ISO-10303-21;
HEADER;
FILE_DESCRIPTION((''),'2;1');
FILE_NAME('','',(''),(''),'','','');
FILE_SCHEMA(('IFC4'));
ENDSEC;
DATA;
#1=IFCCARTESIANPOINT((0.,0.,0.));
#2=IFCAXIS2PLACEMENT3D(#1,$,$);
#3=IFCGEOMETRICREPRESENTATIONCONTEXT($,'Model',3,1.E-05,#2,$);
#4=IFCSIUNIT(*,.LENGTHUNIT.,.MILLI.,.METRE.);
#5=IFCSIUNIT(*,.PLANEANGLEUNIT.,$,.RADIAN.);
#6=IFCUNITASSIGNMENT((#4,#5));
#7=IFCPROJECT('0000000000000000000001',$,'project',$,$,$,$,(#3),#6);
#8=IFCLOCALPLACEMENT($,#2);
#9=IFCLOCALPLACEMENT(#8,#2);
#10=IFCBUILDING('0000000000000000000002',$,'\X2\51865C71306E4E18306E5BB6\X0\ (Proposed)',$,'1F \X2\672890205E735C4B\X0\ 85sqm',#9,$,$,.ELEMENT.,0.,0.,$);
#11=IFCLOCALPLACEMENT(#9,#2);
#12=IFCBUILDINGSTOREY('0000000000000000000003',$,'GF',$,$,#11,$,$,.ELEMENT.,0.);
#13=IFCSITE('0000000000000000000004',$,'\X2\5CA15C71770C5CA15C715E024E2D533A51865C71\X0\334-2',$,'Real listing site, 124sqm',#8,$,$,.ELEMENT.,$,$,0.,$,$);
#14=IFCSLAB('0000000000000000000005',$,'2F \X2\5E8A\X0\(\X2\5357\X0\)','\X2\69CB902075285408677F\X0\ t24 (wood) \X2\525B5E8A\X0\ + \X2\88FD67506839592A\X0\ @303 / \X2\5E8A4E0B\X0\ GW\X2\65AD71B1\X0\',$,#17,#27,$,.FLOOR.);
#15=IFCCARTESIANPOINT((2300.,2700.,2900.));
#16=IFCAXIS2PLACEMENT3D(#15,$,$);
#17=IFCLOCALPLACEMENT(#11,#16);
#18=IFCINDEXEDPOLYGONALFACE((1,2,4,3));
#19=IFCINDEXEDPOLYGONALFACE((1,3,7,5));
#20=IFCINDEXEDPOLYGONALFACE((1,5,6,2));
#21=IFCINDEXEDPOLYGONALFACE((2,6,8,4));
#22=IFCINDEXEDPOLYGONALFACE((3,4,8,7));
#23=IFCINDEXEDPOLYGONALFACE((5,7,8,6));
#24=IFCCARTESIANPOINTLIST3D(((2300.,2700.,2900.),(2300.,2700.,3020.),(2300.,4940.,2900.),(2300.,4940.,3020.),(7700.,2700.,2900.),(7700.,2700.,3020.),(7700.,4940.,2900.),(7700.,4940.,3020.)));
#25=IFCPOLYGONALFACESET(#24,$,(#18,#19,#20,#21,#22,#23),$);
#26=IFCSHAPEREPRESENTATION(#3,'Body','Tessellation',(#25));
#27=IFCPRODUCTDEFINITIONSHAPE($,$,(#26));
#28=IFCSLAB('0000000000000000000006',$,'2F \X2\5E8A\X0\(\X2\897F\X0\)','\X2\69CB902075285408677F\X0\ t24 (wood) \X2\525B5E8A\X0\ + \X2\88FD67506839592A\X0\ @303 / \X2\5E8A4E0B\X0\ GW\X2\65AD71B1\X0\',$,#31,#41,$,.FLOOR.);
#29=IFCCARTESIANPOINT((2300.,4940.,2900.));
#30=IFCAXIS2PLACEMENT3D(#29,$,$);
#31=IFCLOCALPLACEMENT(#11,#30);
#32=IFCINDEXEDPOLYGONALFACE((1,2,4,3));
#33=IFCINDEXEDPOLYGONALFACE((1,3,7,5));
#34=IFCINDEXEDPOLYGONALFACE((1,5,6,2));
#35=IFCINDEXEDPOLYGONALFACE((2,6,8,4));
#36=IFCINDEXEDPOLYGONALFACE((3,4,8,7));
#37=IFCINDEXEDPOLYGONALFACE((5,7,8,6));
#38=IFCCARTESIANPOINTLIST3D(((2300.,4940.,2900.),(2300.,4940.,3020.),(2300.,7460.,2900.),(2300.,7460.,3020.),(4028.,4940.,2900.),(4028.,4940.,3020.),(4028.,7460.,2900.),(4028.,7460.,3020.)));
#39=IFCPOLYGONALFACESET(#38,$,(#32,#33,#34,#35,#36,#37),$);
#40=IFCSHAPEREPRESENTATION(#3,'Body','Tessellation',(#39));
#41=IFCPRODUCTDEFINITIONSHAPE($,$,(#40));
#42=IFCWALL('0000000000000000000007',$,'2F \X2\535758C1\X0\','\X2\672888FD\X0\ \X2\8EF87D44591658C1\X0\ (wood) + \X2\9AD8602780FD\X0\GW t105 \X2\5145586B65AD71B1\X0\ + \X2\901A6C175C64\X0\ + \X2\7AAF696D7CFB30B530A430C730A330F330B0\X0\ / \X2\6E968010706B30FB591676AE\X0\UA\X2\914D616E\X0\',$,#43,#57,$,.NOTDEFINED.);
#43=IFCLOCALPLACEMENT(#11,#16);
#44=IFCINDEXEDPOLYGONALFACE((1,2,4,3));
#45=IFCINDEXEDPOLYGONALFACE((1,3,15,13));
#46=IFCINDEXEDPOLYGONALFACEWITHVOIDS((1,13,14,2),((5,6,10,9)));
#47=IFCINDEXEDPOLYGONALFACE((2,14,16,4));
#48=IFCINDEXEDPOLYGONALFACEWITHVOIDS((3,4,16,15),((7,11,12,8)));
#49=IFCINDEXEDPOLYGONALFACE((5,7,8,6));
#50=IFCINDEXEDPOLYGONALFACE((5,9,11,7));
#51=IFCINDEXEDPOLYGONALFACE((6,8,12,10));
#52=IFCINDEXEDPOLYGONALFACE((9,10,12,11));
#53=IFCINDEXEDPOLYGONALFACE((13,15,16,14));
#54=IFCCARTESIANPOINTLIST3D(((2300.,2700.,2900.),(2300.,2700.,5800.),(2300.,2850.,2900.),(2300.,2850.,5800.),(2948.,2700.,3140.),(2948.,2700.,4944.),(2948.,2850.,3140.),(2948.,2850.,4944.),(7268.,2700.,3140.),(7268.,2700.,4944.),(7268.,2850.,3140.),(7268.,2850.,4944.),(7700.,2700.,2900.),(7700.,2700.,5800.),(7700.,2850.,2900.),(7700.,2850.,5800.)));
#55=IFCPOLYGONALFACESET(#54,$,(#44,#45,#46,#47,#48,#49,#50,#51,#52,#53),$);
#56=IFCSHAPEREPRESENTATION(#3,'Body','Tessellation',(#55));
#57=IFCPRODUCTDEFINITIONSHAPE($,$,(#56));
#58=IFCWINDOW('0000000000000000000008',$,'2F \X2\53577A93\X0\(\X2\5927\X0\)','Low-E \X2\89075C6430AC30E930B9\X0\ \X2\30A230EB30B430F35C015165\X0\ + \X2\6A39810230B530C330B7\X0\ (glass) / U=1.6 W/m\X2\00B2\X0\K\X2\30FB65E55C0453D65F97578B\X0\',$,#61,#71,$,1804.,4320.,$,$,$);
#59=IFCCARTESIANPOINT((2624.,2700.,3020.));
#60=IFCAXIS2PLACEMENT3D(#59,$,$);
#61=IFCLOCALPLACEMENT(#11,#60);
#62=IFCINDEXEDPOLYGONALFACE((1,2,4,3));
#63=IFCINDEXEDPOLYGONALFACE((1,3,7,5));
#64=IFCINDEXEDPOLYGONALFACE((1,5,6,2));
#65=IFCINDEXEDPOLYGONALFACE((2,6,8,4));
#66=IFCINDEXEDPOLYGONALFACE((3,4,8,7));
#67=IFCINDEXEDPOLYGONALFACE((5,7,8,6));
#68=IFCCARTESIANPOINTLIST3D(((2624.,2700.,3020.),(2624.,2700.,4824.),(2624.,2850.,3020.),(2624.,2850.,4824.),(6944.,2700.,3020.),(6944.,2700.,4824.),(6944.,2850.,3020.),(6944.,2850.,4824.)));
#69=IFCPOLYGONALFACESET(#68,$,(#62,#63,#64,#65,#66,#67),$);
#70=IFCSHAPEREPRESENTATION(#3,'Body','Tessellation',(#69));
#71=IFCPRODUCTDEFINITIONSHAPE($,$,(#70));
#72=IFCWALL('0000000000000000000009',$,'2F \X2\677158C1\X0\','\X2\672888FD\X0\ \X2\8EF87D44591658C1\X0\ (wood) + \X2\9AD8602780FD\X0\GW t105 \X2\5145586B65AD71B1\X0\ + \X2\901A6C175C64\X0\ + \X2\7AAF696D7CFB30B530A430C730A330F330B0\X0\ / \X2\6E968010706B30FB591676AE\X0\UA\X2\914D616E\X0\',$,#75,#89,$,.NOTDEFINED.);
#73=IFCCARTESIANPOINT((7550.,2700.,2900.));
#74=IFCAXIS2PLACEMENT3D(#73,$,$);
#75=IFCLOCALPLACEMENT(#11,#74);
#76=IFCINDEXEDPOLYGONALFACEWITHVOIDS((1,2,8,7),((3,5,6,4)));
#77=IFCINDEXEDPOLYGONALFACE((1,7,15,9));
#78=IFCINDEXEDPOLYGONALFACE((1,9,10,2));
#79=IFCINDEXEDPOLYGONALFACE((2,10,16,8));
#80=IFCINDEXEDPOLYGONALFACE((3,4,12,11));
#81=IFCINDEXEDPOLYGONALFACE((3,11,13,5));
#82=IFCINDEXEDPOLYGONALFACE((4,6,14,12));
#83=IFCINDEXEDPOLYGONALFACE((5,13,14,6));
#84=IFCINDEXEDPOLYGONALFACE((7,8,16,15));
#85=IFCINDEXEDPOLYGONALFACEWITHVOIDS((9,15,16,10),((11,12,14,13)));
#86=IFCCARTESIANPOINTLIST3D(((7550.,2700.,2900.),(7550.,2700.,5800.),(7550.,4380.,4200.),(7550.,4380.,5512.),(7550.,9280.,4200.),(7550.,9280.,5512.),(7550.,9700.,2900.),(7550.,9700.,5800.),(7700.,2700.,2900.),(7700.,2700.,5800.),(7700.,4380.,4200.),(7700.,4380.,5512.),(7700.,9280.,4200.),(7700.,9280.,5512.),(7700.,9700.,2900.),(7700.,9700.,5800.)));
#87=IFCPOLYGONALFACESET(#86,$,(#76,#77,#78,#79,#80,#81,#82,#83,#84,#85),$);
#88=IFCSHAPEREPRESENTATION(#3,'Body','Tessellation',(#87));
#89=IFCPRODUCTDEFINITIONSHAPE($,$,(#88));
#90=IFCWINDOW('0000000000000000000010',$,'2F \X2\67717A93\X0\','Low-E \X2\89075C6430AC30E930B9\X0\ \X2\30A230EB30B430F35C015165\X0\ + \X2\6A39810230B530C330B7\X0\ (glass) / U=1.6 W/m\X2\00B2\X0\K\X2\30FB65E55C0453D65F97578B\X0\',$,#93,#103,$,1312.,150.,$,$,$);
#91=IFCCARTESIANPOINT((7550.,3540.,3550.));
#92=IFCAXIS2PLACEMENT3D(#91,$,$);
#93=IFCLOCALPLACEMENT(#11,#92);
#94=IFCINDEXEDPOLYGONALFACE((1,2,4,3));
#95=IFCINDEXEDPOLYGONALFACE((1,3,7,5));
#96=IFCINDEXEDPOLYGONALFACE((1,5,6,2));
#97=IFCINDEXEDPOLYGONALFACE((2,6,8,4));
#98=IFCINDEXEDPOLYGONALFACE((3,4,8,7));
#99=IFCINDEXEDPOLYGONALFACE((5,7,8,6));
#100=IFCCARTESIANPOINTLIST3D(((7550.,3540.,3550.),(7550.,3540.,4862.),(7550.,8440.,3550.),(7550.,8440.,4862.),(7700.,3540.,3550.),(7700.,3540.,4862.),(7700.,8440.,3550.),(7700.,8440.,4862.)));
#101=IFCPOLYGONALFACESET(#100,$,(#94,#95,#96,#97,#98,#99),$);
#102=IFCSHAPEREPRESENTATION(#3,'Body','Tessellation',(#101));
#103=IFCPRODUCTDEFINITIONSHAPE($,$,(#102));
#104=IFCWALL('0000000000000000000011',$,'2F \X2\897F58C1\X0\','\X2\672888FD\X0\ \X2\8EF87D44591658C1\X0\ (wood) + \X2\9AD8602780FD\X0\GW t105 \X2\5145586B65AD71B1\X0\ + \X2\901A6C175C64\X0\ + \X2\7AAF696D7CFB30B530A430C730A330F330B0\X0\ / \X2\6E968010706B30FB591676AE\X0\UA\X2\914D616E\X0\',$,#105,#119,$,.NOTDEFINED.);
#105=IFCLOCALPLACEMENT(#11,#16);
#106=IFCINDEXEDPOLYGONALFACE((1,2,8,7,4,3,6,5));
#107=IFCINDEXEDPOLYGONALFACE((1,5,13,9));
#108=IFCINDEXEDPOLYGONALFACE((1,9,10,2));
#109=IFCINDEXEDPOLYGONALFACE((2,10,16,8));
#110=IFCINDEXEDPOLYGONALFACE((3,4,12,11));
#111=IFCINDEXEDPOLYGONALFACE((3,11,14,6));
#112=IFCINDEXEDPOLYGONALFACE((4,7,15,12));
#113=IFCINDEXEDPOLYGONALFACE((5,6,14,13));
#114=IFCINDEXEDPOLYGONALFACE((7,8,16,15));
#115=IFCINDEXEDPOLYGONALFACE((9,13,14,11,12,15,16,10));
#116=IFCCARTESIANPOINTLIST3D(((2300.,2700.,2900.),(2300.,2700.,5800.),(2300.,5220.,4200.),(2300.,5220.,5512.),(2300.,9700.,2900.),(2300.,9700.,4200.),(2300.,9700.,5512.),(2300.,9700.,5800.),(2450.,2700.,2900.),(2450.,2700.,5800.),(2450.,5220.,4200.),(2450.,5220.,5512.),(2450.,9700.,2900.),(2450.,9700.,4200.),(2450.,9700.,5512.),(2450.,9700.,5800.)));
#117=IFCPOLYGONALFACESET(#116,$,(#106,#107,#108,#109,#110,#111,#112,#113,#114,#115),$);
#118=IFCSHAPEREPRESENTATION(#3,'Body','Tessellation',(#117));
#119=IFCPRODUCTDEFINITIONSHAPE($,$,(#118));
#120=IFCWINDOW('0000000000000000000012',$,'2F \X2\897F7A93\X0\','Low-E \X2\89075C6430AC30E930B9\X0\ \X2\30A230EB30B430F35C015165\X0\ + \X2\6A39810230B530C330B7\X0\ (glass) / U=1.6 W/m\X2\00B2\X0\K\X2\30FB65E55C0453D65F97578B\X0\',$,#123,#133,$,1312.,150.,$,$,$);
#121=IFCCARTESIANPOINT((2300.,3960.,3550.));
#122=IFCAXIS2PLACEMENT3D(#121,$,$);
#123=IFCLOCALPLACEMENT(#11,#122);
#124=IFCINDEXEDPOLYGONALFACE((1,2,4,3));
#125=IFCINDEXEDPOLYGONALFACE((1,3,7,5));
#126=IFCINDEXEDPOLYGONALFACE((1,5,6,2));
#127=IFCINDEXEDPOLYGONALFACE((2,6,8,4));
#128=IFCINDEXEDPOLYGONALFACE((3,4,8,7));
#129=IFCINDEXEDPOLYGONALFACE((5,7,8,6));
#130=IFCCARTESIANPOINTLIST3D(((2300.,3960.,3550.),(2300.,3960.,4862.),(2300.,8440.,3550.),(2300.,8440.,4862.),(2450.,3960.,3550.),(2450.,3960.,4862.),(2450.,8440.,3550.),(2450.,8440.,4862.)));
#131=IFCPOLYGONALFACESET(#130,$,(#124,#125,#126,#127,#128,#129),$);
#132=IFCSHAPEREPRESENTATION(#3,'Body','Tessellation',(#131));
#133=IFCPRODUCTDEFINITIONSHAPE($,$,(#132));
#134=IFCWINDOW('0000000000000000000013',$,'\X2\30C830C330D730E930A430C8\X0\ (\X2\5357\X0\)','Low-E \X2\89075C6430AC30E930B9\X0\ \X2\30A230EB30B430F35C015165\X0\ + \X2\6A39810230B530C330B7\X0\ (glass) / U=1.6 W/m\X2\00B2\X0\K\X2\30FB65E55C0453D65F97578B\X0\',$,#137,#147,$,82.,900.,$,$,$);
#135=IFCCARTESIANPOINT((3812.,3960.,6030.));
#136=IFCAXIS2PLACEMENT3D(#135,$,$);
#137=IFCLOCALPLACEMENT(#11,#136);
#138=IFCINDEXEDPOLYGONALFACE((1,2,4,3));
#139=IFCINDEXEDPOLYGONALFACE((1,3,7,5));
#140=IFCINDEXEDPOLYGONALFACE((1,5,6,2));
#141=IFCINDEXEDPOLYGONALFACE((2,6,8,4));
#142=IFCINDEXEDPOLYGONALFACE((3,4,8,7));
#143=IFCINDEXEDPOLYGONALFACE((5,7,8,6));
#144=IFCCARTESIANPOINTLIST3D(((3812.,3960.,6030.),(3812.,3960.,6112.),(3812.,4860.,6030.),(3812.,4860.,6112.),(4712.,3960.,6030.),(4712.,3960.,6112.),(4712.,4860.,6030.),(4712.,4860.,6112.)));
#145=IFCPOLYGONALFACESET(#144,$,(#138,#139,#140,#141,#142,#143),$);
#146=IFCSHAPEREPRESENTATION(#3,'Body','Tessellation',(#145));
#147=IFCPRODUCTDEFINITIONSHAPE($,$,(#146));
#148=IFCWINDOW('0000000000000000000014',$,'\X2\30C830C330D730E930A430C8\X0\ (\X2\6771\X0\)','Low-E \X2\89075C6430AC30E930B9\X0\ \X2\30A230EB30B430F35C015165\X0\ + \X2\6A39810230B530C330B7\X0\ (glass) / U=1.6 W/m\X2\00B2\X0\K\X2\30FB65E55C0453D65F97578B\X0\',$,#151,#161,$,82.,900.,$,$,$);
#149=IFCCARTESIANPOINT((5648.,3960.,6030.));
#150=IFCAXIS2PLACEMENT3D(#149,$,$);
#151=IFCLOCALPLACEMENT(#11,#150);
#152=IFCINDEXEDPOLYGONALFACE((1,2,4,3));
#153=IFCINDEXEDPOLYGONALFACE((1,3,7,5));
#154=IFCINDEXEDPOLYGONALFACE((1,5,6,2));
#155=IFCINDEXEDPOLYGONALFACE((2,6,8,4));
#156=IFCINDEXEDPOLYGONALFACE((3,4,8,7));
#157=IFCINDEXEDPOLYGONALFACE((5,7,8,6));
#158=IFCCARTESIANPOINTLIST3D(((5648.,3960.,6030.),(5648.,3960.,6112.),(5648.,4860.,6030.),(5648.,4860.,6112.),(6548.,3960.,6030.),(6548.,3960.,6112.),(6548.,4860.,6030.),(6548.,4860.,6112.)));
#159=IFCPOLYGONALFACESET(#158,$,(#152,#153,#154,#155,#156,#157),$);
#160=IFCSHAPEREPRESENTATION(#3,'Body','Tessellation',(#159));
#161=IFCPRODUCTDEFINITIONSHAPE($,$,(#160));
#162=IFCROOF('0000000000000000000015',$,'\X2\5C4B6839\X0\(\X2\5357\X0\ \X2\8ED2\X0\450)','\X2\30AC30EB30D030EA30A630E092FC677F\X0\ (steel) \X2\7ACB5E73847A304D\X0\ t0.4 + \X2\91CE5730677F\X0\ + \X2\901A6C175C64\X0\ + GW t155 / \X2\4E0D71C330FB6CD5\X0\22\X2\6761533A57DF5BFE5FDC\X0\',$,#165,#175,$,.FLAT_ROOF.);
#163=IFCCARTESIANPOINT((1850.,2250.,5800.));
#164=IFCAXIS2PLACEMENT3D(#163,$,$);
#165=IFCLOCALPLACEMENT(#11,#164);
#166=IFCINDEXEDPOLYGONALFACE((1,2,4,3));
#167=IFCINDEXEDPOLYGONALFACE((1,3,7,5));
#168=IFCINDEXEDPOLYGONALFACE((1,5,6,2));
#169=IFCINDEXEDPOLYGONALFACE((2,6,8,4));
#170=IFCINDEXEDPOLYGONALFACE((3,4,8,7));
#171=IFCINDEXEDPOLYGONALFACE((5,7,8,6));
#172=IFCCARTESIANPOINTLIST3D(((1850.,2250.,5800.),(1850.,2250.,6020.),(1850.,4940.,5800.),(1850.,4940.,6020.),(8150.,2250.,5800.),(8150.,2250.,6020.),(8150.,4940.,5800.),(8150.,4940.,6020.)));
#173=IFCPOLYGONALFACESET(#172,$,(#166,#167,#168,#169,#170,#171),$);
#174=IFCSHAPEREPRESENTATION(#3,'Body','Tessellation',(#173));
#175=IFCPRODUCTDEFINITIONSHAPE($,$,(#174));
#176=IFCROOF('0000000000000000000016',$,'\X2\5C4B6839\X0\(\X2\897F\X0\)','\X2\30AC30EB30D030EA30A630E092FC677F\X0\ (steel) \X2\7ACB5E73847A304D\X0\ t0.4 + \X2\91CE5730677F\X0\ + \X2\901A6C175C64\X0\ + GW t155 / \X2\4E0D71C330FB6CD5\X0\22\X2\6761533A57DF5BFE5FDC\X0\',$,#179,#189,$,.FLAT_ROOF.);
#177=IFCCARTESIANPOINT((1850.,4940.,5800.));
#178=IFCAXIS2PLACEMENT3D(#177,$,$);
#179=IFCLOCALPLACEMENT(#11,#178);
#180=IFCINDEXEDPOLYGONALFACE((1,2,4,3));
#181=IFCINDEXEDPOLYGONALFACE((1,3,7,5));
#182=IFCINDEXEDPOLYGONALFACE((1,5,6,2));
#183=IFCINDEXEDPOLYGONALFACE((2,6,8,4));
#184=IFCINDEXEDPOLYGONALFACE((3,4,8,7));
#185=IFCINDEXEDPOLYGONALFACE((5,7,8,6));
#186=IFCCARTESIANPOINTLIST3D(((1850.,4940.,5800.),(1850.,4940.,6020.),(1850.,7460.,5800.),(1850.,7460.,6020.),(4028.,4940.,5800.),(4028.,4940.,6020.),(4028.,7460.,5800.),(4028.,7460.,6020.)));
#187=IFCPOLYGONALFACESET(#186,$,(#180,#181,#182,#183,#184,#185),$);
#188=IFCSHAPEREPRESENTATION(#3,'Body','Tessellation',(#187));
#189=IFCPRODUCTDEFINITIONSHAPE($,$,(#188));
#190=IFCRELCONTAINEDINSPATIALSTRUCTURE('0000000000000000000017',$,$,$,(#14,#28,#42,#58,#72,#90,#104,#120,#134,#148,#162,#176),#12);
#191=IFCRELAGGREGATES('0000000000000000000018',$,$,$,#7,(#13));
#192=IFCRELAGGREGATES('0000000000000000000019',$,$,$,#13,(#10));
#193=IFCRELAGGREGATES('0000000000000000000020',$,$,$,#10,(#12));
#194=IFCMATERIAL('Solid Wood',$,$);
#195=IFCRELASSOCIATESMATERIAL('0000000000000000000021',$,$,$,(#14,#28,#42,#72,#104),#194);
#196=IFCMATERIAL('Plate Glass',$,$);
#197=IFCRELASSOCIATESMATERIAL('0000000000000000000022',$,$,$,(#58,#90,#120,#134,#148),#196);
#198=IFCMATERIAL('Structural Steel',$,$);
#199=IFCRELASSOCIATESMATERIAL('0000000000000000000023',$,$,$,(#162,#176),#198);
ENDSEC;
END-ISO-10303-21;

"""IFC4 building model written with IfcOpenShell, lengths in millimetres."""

from ifc_helpers import new_model, si_unit, frame, frame_2d, origin, place, context, project, spatial, rectangle, extrude, material, element, fill, save


model = new_model("IFC4")

# Units and contexts
model_context = context("Model", 3, precision=1e-05, world=origin())
ifc_project = project(units=[si_unit("LENGTHUNIT", "METRE", prefix="MILLI"), si_unit("PLANEANGLEUNIT", "RADIAN")], contexts=[model_context])

# Site, building, storey
site_placement = place(None, origin())
site = spatial("IfcSite", under=ifc_project, at=site_placement, Name="岡山県岡山市中区円山334-2", ObjectType="Real listing site, 124sqm", CompositionType="ELEMENT", RefElevation=0.0)
building_placement = place(site_placement, origin())
building = spatial("IfcBuilding", under=site, at=building_placement, Name="円山の丘の家 (Proposed)", ObjectType="1F 木造平屋 85sqm", CompositionType="ELEMENT", ElevationOfRefHeight=0.0, ElevationOfTerrain=0.0)
storey_placement = place(building_placement, origin())
storey = spatial("IfcBuildingStorey", under=building, at=storey_placement, Name="GF", CompositionType="ELEMENT", Elevation=0.0)

# Slabs
ifc_material_1 = material(Name="Solid Wood")
slab_1_placement = place(storey_placement, frame((2300.0, 2700.0, 2900.0)))
element("IfcSlab", 1, at=slab_1_placement, inside=storey, material=ifc_material_1, Name="2F 床(南)", Description="構造用合板 t24 (wood) 剛床 + 製材根太 @303 / 床下 GW断熱", PredefinedType="FLOOR", context=model_context, shape_type="SweptSolid", body=[
    extrude(rectangle(XDim=5400.0, YDim=2240.0, at=frame_2d((2700.0, 1120.0))), frame((2300.0, 2700.0, 2900.0)), (0.0, 0.0, 1.0), 120.0),
])
slab_2_placement = place(storey_placement, frame((2300.0, 4940.0, 2900.0)))
element("IfcSlab", 2, at=slab_2_placement, inside=storey, material=ifc_material_1, Name="2F 床(西)", Description="構造用合板 t24 (wood) 剛床 + 製材根太 @303 / 床下 GW断熱", PredefinedType="FLOOR", context=model_context, shape_type="SweptSolid", body=[
    extrude(rectangle(XDim=1728.0, YDim=2520.0, at=frame_2d((864.0, 1260.0))), frame((2300.0, 4940.0, 2900.0)), (0.0, 0.0, 1.0), 120.0),
])

# Walls, openings, windows
wall_1_placement = place(storey_placement, frame((2300.0, 2700.0, 2900.0)))
wall_1 = element("IfcWall", 3, at=wall_1_placement, inside=storey, material=ifc_material_1, Name="2F 南壁", Description="木製 軸組外壁 (wood) + 高性能GW t105 充填断熱 + 通気層 + 窯業系サイディング / 準耐火・外皮UA配慮", PredefinedType="NOTDEFINED", context=model_context, shape_type="SweptSolid", body=[
    extrude(rectangle(XDim=5400.0, YDim=150.0, at=frame_2d((2700.0, 75.0))), frame((2300.0, 2700.0, 2900.0)), (0.0, 0.0, 1.0), 2900.0),
])
opening_1_placement = place(storey_placement, frame((2624.0, 2700.0, 3020.0)))
opening_1 = element("IfcOpeningElement", 4, at=opening_1_placement, cuts=wall_1, PredefinedType="NOTDEFINED", context=model_context, shape_type="SweptSolid", body=[
    extrude(rectangle(XDim=4320.0, YDim=150.0, at=frame_2d((2160.0, 75.0))), frame((2624.0, 2700.0, 3020.0)), (0.0, 0.0, 1.0), 1804.0),
])
ifc_material_2 = material(Name="Plate Glass")
window_1_placement = place(storey_placement, frame((2624.0, 2700.0, 3020.0)))
window_1 = element("IfcWindow", 5, at=window_1_placement, inside=storey, material=ifc_material_2, Name="2F 南窓(大)", Description="Low-E 複層ガラス アルゴン封入 + 樹脂サッシ (glass) / U=1.6 W/m²K・日射取得型", OverallHeight=1804.0, OverallWidth=4320.0, context=model_context, shape_type="SweptSolid", body=[
    extrude(rectangle(XDim=4320.0, YDim=150.0, at=frame_2d((2160.0, 75.0))), frame((2624.0, 2700.0, 3020.0)), (0.0, 0.0, 1.0), 1804.0),
])
fill(opening_1, window_1)
wall_2_placement = place(storey_placement, frame((7550.0, 2700.0, 2900.0)))
wall_2 = element("IfcWall", 6, at=wall_2_placement, inside=storey, material=ifc_material_1, Name="2F 東壁", Description="木製 軸組外壁 (wood) + 高性能GW t105 充填断熱 + 通気層 + 窯業系サイディング / 準耐火・外皮UA配慮", PredefinedType="NOTDEFINED", context=model_context, shape_type="SweptSolid", body=[
    extrude(rectangle(XDim=150.0, YDim=7000.0, at=frame_2d((75.0, 3500.0))), frame((7550.0, 2700.0, 2900.0)), (0.0, 0.0, 1.0), 2900.0),
])
opening_2_placement = place(storey_placement, frame((7550.0, 3540.0, 3550.0)))
opening_2 = element("IfcOpeningElement", 7, at=opening_2_placement, cuts=wall_2, PredefinedType="NOTDEFINED", context=model_context, shape_type="SweptSolid", body=[
    extrude(rectangle(XDim=150.0, YDim=4900.0, at=frame_2d((75.0, 2450.0))), frame((7550.0, 3540.0, 3550.0)), (0.0, 0.0, 1.0), 1312.0),
])
window_2_placement = place(storey_placement, frame((7550.0, 3540.0, 3550.0)))
window_2 = element("IfcWindow", 8, at=window_2_placement, inside=storey, material=ifc_material_2, Name="2F 東窓", Description="Low-E 複層ガラス アルゴン封入 + 樹脂サッシ (glass) / U=1.6 W/m²K・日射取得型", OverallHeight=1312.0, OverallWidth=150.0, context=model_context, shape_type="SweptSolid", body=[
    extrude(rectangle(XDim=150.0, YDim=4900.0, at=frame_2d((75.0, 2450.0))), frame((7550.0, 3540.0, 3550.0)), (0.0, 0.0, 1.0), 1312.0),
])
fill(opening_2, window_2)
wall_3_placement = place(storey_placement, frame((2300.0, 2700.0, 2900.0)))
wall_3 = element("IfcWall", 9, at=wall_3_placement, inside=storey, material=ifc_material_1, Name="2F 西壁", Description="木製 軸組外壁 (wood) + 高性能GW t105 充填断熱 + 通気層 + 窯業系サイディング / 準耐火・外皮UA配慮", PredefinedType="NOTDEFINED", context=model_context, shape_type="SweptSolid", body=[
    extrude(rectangle(XDim=150.0, YDim=7000.0, at=frame_2d((75.0, 3500.0))), frame((2300.0, 2700.0, 2900.0)), (0.0, 0.0, 1.0), 2900.0),
])
opening_3_placement = place(storey_placement, frame((2300.0, 3960.0, 3550.0)))
opening_3 = element("IfcOpeningElement", 10, at=opening_3_placement, cuts=wall_3, PredefinedType="NOTDEFINED", context=model_context, shape_type="SweptSolid", body=[
    extrude(rectangle(XDim=150.0, YDim=4480.0, at=frame_2d((75.0, 2240.0))), frame((2300.0, 3960.0, 3550.0)), (0.0, 0.0, 1.0), 1312.0),
])
window_3_placement = place(storey_placement, frame((2300.0, 3960.0, 3550.0)))
window_3 = element("IfcWindow", 11, at=window_3_placement, inside=storey, material=ifc_material_2, Name="2F 西窓", Description="Low-E 複層ガラス アルゴン封入 + 樹脂サッシ (glass) / U=1.6 W/m²K・日射取得型", OverallHeight=1312.0, OverallWidth=150.0, context=model_context, shape_type="SweptSolid", body=[
    extrude(rectangle(XDim=150.0, YDim=4480.0, at=frame_2d((75.0, 2240.0))), frame((2300.0, 3960.0, 3550.0)), (0.0, 0.0, 1.0), 1312.0),
])
fill(opening_3, window_3)

# Windows
window_4_placement = place(storey_placement, frame((3812.0, 3960.0, 6030.0)))
element("IfcWindow", 12, at=window_4_placement, inside=storey, material=ifc_material_2, Name="トップライト (南)", Description="Low-E 複層ガラス アルゴン封入 + 樹脂サッシ (glass) / U=1.6 W/m²K・日射取得型", OverallHeight=82.0, OverallWidth=900.0, context=model_context, shape_type="SweptSolid", body=[
    extrude(rectangle(XDim=900.0, YDim=900.0, at=frame_2d((450.0, 450.0))), frame((3812.0, 3960.0, 6030.0)), (0.0, 0.0, 1.0), 82.0),
])
window_5_placement = place(storey_placement, frame((5648.0, 3960.0, 6030.0)))
element("IfcWindow", 13, at=window_5_placement, inside=storey, material=ifc_material_2, Name="トップライト (東)", Description="Low-E 複層ガラス アルゴン封入 + 樹脂サッシ (glass) / U=1.6 W/m²K・日射取得型", OverallHeight=82.0, OverallWidth=900.0, context=model_context, shape_type="SweptSolid", body=[
    extrude(rectangle(XDim=900.0, YDim=900.0, at=frame_2d((450.0, 450.0))), frame((5648.0, 3960.0, 6030.0)), (0.0, 0.0, 1.0), 82.0),
])

# Roofs
ifc_material_3 = material(Name="Structural Steel")
roof_1_placement = place(storey_placement, frame((1850.0, 2250.0, 5800.0)))
element("IfcRoof", 14, at=roof_1_placement, inside=storey, material=ifc_material_3, Name="屋根(南 軒450)", Description="ガルバリウム鋼板 (steel) 立平葺き t0.4 + 野地板 + 通気層 + GW t155 / 不燃・法22条区域対応", PredefinedType="FLAT_ROOF", context=model_context, shape_type="SweptSolid", body=[
    extrude(rectangle(XDim=6300.0, YDim=2690.0, at=frame_2d((3150.0, 1345.0))), frame((1850.0, 2250.0, 5800.0)), (0.0, 0.0, 1.0), 220.0),
])
roof_2_placement = place(storey_placement, frame((1850.0, 4940.0, 5800.0)))
element("IfcRoof", 15, at=roof_2_placement, inside=storey, material=ifc_material_3, Name="屋根(西)", Description="ガルバリウム鋼板 (steel) 立平葺き t0.4 + 野地板 + 通気層 + GW t155 / 不燃・法22条区域対応", PredefinedType="FLAT_ROOF", context=model_context, shape_type="SweptSolid", body=[
    extrude(rectangle(XDim=2178.0, YDim=2520.0, at=frame_2d((1089.0, 1260.0))), frame((1850.0, 4940.0, 5800.0)), (0.0, 0.0, 1.0), 220.0),
])

save(model, "model.ifc")
